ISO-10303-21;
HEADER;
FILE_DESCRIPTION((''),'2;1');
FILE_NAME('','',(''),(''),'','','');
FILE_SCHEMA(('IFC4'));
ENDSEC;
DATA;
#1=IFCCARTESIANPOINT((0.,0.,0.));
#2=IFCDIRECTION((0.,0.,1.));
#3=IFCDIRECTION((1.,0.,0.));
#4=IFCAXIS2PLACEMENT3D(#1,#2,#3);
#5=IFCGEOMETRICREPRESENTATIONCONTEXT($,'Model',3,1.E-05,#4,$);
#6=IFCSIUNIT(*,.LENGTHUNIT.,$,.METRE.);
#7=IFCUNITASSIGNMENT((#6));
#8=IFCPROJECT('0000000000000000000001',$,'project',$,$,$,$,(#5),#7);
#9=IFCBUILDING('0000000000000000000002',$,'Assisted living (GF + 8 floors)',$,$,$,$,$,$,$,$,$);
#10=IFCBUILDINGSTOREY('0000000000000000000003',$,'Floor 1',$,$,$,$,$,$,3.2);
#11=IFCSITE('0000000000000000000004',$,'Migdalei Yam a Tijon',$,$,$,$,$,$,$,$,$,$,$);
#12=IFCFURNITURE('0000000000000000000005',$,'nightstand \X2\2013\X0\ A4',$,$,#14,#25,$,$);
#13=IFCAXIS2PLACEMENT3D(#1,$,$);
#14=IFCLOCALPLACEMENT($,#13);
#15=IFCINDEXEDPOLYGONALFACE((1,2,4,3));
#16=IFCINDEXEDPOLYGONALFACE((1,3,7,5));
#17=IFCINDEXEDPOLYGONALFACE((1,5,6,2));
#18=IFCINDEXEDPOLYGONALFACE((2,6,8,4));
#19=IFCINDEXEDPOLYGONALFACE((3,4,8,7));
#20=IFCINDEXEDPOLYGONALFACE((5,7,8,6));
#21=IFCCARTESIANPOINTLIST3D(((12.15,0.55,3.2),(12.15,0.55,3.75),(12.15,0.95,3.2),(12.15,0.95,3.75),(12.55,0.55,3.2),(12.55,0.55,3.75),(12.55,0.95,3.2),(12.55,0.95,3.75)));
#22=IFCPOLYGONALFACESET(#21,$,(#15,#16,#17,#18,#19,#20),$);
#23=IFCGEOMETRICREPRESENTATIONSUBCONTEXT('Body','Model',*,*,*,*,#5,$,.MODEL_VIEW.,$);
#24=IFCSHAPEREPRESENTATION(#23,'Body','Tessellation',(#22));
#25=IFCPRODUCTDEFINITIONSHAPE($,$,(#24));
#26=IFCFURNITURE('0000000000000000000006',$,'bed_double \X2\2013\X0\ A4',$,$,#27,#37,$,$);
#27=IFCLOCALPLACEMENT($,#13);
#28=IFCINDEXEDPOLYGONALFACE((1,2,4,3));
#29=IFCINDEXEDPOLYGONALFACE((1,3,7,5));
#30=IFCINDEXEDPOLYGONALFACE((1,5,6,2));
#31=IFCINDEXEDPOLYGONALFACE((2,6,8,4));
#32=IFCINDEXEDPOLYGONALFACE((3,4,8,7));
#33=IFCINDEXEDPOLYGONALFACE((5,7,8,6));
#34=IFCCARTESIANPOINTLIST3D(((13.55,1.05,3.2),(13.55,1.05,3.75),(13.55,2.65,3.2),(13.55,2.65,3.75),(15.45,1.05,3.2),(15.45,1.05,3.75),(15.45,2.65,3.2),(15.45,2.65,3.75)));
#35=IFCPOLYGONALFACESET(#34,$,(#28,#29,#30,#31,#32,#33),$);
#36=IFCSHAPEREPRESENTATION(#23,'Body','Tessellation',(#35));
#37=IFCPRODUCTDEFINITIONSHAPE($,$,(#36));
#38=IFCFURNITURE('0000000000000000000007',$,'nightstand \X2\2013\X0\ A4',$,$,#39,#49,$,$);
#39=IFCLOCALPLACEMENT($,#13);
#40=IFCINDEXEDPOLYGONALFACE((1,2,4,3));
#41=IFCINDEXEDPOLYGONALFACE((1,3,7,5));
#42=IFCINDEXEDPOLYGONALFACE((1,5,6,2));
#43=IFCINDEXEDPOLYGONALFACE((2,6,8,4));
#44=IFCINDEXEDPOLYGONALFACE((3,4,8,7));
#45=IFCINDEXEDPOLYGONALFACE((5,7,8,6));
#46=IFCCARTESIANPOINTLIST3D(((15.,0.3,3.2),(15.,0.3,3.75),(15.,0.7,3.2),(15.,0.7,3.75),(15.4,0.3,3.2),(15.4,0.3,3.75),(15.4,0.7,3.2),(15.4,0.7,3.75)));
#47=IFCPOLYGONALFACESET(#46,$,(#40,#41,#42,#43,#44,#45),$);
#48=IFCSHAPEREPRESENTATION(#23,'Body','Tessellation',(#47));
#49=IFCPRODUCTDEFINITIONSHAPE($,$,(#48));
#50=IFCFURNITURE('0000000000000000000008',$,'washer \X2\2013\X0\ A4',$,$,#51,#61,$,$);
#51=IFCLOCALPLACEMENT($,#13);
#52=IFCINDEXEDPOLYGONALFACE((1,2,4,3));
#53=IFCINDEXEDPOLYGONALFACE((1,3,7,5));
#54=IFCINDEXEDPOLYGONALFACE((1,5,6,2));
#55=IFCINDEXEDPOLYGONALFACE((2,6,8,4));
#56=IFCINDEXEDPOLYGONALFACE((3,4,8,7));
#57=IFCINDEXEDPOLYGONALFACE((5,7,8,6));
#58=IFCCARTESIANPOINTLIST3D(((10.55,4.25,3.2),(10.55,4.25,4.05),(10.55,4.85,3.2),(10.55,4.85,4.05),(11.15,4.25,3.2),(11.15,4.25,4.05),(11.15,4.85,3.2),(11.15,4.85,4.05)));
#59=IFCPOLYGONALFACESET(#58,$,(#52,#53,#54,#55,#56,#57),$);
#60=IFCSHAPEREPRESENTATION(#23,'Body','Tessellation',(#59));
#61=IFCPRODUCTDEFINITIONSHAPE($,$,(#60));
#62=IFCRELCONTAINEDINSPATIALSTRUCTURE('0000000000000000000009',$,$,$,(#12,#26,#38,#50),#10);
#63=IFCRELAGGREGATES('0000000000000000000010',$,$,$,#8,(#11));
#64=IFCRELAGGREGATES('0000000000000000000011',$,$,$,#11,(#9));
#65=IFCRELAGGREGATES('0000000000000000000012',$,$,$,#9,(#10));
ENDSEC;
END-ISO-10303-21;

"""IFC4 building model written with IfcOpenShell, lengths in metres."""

from ifc_helpers import new_model, si_unit, frame, origin_with_axes, context, subcontext, project, spatial, line, indexed_curve, outline, extrude, element, save


model = new_model("IFC4")

# Units and contexts
model_context = context("Model", 3, precision=1e-05, world=origin_with_axes())
body_context = subcontext(model_context, "Body", "Model", "MODEL_VIEW")
ifc_project = project(units=[si_unit("LENGTHUNIT", "METRE")], contexts=[model_context])

# Site, building, storey
site = spatial("IfcSite", under=ifc_project, Name="Migdalei Yam a Tijon")
building = spatial("IfcBuilding", under=site, Name="Assisted living (GF + 8 floors)")
storey = spatial("IfcBuildingStorey", under=building, Name="Floor 1", Elevation=3.2)

# Furniture
element("IfcFurniture", 1, inside=storey, Name="nightstand – A4", context=body_context, shape_type="SweptSolid", body=[
    extrude(outline(indexed_curve([(0.0, 0.0), (0.4, 0.0), (0.4, 0.4), (0.0, 0.4)], segments=[line(1, 2, 3, 4, 1)])), frame((12.15, 0.55, 3.2), z_axis=(0.0, 0.0, 1.0), x_axis=(1.0, 0.0, 0.0)), (0.0, 0.0, 1.0), 0.55),
])
element("IfcFurniture", 2, inside=storey, Name="bed_double – A4", context=body_context, shape_type="SweptSolid", body=[
    extrude(outline(indexed_curve([(0.0, 0.0), (1.9, 0.0), (1.9, 1.6), (0.0, 1.6)], segments=[line(1, 2, 3, 4, 1)])), frame((13.55, 1.05, 3.2), z_axis=(0.0, 0.0, 1.0), x_axis=(1.0, 0.0, 0.0)), (0.0, 0.0, 1.0), 0.55),
])
element("IfcFurniture", 3, inside=storey, Name="nightstand – A4", context=body_context, shape_type="SweptSolid", body=[
    extrude(outline(indexed_curve([(0.0, 0.0), (0.4, 0.0), (0.4, 0.4), (0.0, 0.4)], segments=[line(1, 2, 3, 4, 1)])), frame((15.0, 0.3, 3.2), z_axis=(0.0, 0.0, 1.0), x_axis=(1.0, 0.0, 0.0)), (0.0, 0.0, 1.0), 0.55),
])
element("IfcFurniture", 4, inside=storey, Name="washer – A4", context=body_context, shape_type="SweptSolid", body=[
    extrude(outline(indexed_curve([(0.0, 0.0), (0.6, 0.0), (0.6, 0.6), (0.0, 0.6)], segments=[line(1, 2, 3, 4, 1)])), frame((10.55, 4.25, 3.2), z_axis=(0.0, 0.0, 1.0), x_axis=(1.0, 0.0, 0.0)), (0.0, 0.0, 1.0), 0.85),
])

save(model, "model.ifc")
